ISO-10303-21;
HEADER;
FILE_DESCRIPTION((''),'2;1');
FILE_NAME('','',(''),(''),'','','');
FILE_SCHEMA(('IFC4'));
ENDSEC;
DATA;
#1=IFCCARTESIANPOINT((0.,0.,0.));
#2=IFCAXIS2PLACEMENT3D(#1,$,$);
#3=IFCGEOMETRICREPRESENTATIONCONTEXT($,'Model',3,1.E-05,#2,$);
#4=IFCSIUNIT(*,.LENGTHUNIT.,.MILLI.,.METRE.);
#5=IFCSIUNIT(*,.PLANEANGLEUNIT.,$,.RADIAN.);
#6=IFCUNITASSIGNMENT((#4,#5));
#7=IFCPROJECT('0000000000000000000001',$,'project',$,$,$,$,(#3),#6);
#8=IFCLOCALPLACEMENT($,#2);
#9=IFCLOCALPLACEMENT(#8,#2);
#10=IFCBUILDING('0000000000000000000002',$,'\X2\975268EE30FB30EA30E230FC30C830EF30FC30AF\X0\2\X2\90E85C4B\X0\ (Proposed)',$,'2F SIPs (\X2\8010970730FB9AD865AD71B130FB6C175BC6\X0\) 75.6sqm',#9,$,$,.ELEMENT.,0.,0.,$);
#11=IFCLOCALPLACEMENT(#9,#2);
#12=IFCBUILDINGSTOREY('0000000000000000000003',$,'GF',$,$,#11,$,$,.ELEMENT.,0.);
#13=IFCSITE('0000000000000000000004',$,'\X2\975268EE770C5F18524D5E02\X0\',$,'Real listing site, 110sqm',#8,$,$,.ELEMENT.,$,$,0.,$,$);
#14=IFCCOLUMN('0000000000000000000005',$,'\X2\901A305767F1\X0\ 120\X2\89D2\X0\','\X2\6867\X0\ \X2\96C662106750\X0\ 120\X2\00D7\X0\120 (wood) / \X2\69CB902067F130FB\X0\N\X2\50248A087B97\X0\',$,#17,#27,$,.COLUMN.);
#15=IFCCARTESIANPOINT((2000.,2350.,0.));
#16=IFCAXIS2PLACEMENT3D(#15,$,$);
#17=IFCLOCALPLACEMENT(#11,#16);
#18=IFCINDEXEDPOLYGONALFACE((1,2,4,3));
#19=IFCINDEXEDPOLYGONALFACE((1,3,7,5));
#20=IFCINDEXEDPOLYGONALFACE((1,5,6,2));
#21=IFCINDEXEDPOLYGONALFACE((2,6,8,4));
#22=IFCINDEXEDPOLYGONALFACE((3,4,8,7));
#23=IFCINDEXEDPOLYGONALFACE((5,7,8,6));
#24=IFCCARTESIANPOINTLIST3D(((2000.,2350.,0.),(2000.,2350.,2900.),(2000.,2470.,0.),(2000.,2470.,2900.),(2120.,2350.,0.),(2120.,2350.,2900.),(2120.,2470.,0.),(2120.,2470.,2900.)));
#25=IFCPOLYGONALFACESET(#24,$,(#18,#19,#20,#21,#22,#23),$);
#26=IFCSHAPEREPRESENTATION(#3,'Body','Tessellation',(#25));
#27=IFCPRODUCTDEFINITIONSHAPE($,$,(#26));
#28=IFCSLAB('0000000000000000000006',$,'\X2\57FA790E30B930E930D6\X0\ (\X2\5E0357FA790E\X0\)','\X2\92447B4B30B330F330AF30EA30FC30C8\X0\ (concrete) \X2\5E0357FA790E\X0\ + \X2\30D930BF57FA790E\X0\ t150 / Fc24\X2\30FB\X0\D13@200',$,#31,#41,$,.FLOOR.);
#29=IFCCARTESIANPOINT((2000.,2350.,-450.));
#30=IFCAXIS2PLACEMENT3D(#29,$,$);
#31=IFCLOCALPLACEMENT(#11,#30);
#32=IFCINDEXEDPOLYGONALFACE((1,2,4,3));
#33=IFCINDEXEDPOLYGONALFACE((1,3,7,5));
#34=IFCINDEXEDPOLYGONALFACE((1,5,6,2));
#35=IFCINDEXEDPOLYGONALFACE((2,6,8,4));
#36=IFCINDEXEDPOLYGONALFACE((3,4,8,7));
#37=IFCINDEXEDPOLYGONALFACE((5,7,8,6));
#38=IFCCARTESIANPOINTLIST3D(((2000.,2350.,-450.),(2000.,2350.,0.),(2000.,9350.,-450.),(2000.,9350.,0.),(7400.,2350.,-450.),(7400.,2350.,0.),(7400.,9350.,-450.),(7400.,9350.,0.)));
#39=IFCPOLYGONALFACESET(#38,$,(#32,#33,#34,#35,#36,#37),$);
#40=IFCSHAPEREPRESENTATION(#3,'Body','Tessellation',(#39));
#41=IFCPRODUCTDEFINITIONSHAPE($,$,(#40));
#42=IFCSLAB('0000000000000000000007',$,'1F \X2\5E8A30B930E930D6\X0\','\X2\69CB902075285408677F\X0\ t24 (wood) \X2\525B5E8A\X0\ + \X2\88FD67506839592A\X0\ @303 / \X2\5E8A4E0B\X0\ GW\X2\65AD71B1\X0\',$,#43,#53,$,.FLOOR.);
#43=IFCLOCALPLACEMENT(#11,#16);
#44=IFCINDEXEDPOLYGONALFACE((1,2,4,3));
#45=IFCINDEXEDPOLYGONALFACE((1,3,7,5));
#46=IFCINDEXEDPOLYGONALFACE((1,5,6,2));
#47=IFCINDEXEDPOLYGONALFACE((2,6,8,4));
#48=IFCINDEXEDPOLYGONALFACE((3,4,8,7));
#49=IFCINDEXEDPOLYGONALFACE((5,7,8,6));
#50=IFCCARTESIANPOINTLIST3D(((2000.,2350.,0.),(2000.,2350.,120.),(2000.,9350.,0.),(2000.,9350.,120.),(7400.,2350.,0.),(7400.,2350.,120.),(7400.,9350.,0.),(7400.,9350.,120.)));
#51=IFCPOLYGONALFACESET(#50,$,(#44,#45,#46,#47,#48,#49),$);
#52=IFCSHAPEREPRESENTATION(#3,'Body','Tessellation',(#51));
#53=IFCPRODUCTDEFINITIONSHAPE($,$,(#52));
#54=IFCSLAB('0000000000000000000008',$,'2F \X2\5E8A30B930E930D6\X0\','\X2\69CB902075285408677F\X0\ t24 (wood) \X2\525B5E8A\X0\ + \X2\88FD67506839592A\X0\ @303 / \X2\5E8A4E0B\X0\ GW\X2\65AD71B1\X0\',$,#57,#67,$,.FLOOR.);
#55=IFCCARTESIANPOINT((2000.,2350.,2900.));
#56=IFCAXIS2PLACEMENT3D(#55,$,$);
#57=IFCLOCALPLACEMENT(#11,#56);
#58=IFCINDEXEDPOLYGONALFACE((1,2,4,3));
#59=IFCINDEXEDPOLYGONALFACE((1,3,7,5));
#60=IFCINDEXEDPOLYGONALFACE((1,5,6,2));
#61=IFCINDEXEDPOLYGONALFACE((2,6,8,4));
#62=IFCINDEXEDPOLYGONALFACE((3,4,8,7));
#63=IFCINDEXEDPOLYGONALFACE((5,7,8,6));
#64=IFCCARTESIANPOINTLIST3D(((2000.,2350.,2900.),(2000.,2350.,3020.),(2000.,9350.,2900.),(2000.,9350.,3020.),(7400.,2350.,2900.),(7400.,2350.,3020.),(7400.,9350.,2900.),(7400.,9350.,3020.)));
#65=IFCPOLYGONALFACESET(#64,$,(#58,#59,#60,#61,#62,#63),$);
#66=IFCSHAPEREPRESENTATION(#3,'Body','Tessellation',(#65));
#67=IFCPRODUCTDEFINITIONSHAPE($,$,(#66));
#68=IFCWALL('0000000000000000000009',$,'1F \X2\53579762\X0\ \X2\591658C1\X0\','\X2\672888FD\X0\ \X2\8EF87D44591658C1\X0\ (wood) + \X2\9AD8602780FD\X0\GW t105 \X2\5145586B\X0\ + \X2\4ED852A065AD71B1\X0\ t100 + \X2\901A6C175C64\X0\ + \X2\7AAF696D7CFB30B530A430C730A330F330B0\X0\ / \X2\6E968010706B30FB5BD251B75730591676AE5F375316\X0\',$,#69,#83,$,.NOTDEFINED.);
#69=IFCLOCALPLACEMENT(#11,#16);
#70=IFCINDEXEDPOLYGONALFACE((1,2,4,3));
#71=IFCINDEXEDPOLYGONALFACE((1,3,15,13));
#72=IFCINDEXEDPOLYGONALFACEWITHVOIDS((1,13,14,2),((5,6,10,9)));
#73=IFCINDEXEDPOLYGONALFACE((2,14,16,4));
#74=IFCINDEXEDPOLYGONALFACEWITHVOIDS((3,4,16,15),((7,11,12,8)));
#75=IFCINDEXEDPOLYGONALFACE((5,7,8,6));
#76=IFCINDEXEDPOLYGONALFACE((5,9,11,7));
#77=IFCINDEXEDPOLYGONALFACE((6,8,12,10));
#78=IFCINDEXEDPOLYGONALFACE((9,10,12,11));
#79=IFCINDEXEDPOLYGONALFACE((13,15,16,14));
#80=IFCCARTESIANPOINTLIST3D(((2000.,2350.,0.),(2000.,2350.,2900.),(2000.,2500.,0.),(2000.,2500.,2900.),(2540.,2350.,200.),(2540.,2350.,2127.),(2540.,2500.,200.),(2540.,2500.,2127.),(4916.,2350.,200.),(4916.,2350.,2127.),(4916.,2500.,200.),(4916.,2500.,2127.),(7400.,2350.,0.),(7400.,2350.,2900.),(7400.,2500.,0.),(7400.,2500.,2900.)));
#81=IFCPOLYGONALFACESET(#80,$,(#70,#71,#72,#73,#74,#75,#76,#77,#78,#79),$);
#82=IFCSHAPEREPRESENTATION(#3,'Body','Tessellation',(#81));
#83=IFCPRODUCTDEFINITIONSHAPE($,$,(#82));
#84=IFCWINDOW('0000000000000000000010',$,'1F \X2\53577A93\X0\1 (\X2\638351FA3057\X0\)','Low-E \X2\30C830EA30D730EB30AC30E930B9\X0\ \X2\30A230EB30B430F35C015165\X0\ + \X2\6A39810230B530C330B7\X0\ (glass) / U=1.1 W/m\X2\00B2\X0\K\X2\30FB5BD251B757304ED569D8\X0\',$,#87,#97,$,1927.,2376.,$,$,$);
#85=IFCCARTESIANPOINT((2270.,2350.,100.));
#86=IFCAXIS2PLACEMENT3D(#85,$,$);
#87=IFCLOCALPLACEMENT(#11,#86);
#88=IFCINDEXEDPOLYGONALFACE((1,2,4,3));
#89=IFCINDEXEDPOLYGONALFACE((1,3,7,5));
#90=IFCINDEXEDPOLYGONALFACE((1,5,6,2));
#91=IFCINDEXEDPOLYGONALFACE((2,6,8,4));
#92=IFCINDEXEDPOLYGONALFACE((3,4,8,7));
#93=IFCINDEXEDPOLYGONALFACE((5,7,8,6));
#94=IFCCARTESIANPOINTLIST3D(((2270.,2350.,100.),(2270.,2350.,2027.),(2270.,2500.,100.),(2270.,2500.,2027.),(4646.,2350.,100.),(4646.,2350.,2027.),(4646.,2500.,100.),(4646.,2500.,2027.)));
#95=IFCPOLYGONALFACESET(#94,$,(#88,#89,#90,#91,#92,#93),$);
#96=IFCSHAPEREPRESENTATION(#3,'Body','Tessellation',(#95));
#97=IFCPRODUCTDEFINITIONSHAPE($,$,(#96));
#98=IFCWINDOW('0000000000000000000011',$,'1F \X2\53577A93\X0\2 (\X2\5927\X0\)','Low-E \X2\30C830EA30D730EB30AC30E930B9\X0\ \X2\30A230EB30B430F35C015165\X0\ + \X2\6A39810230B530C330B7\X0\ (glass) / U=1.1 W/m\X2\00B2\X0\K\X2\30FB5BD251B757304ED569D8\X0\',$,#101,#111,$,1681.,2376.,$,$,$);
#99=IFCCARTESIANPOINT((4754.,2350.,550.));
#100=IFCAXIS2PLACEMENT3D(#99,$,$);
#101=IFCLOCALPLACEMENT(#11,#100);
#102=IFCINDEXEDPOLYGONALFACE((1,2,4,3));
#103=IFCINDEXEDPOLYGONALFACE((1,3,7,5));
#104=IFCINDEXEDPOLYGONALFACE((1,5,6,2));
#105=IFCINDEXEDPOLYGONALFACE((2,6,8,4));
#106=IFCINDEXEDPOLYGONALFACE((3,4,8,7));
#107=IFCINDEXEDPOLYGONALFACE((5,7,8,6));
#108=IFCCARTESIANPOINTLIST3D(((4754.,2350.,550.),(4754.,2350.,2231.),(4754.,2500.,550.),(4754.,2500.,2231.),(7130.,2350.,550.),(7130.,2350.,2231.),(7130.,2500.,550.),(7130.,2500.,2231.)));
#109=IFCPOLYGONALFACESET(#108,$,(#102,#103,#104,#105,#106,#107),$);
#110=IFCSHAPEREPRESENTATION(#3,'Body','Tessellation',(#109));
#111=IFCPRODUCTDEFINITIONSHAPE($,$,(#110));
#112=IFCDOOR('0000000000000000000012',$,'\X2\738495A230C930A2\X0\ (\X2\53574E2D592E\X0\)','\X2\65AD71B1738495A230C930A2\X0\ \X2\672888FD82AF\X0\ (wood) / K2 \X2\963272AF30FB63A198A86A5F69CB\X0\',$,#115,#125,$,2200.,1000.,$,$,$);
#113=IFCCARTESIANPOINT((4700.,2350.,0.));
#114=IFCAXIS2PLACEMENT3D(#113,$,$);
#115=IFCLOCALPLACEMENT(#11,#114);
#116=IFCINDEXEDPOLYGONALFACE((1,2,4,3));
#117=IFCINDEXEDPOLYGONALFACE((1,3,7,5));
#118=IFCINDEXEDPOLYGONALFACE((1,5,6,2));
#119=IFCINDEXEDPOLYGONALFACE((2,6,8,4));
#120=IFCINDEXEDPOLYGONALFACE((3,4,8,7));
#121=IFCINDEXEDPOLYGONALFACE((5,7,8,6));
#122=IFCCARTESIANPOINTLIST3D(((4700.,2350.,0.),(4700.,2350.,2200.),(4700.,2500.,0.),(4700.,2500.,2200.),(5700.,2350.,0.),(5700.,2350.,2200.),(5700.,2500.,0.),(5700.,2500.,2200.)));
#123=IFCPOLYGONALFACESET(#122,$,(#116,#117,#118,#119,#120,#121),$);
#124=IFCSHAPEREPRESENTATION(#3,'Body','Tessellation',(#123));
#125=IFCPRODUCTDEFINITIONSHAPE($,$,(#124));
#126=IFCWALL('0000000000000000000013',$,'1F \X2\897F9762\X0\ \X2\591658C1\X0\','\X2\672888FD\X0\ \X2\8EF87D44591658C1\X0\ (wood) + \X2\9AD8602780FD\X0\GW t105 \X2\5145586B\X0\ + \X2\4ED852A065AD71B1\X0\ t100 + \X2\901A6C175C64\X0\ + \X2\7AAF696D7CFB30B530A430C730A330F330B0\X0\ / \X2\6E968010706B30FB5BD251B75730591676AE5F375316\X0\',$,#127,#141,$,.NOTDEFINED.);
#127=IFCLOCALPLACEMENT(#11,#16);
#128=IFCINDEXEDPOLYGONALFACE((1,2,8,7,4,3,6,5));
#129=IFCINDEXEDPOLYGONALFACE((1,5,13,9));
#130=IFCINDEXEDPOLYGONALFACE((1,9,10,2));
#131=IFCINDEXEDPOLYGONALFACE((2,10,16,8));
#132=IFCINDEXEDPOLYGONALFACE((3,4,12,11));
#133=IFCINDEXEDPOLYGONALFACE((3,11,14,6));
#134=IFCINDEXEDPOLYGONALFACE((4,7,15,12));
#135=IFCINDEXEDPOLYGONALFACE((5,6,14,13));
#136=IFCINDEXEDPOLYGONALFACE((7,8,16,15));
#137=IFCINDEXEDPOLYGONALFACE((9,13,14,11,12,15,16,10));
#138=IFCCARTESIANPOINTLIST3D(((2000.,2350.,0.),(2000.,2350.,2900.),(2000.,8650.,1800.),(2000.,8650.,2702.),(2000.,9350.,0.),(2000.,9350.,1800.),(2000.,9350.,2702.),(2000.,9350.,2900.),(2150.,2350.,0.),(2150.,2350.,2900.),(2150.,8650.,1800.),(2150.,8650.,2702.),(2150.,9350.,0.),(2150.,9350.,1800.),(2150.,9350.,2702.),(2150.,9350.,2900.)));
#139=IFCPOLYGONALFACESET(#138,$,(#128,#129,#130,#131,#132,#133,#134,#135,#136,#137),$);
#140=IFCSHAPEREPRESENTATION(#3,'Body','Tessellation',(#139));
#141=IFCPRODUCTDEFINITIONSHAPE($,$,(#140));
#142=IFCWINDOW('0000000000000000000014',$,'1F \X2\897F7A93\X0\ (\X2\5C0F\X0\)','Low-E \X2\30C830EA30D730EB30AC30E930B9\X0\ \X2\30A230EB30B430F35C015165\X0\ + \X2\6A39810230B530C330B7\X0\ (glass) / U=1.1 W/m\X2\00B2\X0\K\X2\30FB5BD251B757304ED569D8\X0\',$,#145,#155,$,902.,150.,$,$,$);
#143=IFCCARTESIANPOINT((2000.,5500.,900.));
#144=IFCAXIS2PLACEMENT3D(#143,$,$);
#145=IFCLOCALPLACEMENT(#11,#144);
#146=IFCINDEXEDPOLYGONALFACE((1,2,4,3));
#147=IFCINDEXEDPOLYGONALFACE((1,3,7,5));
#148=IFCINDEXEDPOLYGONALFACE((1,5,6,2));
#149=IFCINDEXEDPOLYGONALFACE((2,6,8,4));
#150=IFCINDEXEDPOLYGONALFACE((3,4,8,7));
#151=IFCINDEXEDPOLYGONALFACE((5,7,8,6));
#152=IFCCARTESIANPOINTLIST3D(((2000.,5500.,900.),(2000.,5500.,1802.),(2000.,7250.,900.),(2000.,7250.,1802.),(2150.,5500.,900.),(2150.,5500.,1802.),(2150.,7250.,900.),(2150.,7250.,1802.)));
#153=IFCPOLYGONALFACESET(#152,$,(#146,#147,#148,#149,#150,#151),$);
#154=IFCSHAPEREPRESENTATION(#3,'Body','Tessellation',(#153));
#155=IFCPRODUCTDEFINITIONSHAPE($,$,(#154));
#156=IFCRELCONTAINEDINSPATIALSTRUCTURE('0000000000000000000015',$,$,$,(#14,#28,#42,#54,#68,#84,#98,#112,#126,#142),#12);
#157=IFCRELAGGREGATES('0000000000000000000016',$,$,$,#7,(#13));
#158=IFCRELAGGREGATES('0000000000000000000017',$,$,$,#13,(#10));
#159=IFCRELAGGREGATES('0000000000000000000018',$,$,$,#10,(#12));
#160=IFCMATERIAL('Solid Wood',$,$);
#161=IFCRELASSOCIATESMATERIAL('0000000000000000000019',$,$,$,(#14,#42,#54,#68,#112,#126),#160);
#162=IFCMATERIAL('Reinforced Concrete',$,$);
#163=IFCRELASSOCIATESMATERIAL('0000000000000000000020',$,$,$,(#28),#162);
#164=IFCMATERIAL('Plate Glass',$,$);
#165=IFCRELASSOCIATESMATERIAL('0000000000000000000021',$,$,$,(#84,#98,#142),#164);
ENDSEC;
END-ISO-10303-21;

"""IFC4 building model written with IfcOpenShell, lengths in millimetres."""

from ifc_helpers import new_model, si_unit, frame, frame_2d, origin, place, context, project, spatial, rectangle, extrude, material, element, fill, save


model = new_model("IFC4")

# Units and contexts
model_context = context("Model", 3, precision=1e-05, world=origin())
ifc_project = project(units=[si_unit("LENGTHUNIT", "METRE", prefix="MILLI"), si_unit("PLANEANGLEUNIT", "RADIAN")], contexts=[model_context])

# Site, building, storey
site_placement = place(None, origin())
site = spatial("IfcSite", under=ifc_project, at=site_placement, Name="青森県弘前市", ObjectType="Real listing site, 110sqm", CompositionType="ELEMENT", RefElevation=0.0)
building_placement = place(site_placement, origin())
building = spatial("IfcBuilding", under=site, at=building_placement, Name="青森・リモートワーク2部屋 (Proposed)", ObjectType="2F SIPs (耐震・高断熱・気密) 75.6sqm", CompositionType="ELEMENT", ElevationOfRefHeight=0.0, ElevationOfTerrain=0.0)
storey_placement = place(building_placement, origin())
storey = spatial("IfcBuildingStorey", under=building, at=storey_placement, Name="GF", CompositionType="ELEMENT", Elevation=0.0)

# Column
ifc_material_1 = material(Name="Solid Wood")
column_placement = place(storey_placement, frame((2000.0, 2350.0, 0.0)))
element("IfcColumn", 1, at=column_placement, inside=storey, material=ifc_material_1, Name="通し柱 120角", Description="桧 集成材 120×120 (wood) / 構造柱・N値計算", PredefinedType="COLUMN", context=model_context, shape_type="SweptSolid", body=[
    extrude(rectangle(XDim=120.0, YDim=120.0, at=frame_2d((60.0, 60.0))), frame((2000.0, 2350.0, 0.0)), (0.0, 0.0, 1.0), 2900.0),
])

# Slabs
ifc_material_2 = material(Name="Reinforced Concrete")
slab_1_placement = place(storey_placement, frame((2000.0, 2350.0, -450.0)))
element("IfcSlab", 2, at=slab_1_placement, inside=storey, material=ifc_material_2, Name="基礎スラブ (布基礎)", Description="鉄筋コンクリート (concrete) 布基礎 + ベタ基礎 t150 / Fc24・D13@200", PredefinedType="FLOOR", context=model_context, shape_type="SweptSolid", body=[
    extrude(rectangle(XDim=5400.0, YDim=7000.0, at=frame_2d((2700.0, 3500.0))), frame((2000.0, 2350.0, -450.0)), (0.0, 0.0, 1.0), 450.0),
])
slab_2_placement = place(storey_placement, frame((2000.0, 2350.0, 0.0)))
element("IfcSlab", 3, at=slab_2_placement, inside=storey, material=ifc_material_1, Name="1F 床スラブ", Description="構造用合板 t24 (wood) 剛床 + 製材根太 @303 / 床下 GW断熱", PredefinedType="FLOOR", context=model_context, shape_type="SweptSolid", body=[
    extrude(rectangle(XDim=5400.0, YDim=7000.0, at=frame_2d((2700.0, 3500.0))), frame((2000.0, 2350.0, 0.0)), (0.0, 0.0, 1.0), 120.0),
])
slab_3_placement = place(storey_placement, frame((2000.0, 2350.0, 2900.0)))
element("IfcSlab", 4, at=slab_3_placement, inside=storey, material=ifc_material_1, Name="2F 床スラブ", Description="構造用合板 t24 (wood) 剛床 + 製材根太 @303 / 床下 GW断熱", PredefinedType="FLOOR", context=model_context, shape_type="SweptSolid", body=[
    extrude(rectangle(XDim=5400.0, YDim=7000.0, at=frame_2d((2700.0, 3500.0))), frame((2000.0, 2350.0, 2900.0)), (0.0, 0.0, 1.0), 120.0),
])

# Wall, openings, windows, door
wall_1_placement = place(storey_placement, frame((2000.0, 2350.0, 0.0)))
wall_1 = element("IfcWall", 5, at=wall_1_placement, inside=storey, material=ifc_material_1, Name="1F 南面 外壁", Description="木製 軸組外壁 (wood) + 高性能GW t105 充填 + 付加断熱 t100 + 通気層 + 窯業系サイディング / 準耐火・寒冷地外皮強化", PredefinedType="NOTDEFINED", context=model_context, shape_type="SweptSolid", body=[
    extrude(rectangle(XDim=5400.0, YDim=150.0, at=frame_2d((2700.0, 75.0))), frame((2000.0, 2350.0, 0.0)), (0.0, 0.0, 1.0), 2900.0),
])
opening_1_placement = place(storey_placement, frame((2270.0, 2350.0, 100.0)))
opening_1 = element("IfcOpeningElement", 6, at=opening_1_placement, cuts=wall_1, PredefinedType="NOTDEFINED", context=model_context, shape_type="SweptSolid", body=[
    extrude(rectangle(XDim=2376.0, YDim=150.0, at=frame_2d((1188.0, 75.0))), frame((2270.0, 2350.0, 100.0)), (0.0, 0.0, 1.0), 1927.0),
])
opening_2_placement = place(storey_placement, frame((4754.0, 2350.0, 550.0)))
opening_2 = element("IfcOpeningElement", 7, at=opening_2_placement, cuts=wall_1, PredefinedType="NOTDEFINED", context=model_context, shape_type="SweptSolid", body=[
    extrude(rectangle(XDim=2376.0, YDim=150.0, at=frame_2d((1188.0, 75.0))), frame((4754.0, 2350.0, 550.0)), (0.0, 0.0, 1.0), 1681.0),
])
opening_3_placement = place(storey_placement, frame((4700.0, 2350.0, 0.0)))
opening_3 = element("IfcOpeningElement", 8, at=opening_3_placement, cuts=wall_1, PredefinedType="NOTDEFINED", context=model_context, shape_type="SweptSolid", body=[
    extrude(rectangle(XDim=1000.0, YDim=150.0, at=frame_2d((500.0, 75.0))), frame((4700.0, 2350.0, 0.0)), (0.0, 0.0, 1.0), 2200.0),
])
ifc_material_3 = material(Name="Plate Glass")
window_1_placement = place(storey_placement, frame((2270.0, 2350.0, 100.0)))
window_1 = element("IfcWindow", 9, at=window_1_placement, inside=storey, material=ifc_material_3, Name="1F 南窓1 (掃出し)", Description="Low-E トリプルガラス アルゴン封入 + 樹脂サッシ (glass) / U=1.1 W/m²K・寒冷地仕様", OverallHeight=1927.0, OverallWidth=2376.0, context=model_context, shape_type="SweptSolid", body=[
    extrude(rectangle(XDim=2376.0, YDim=150.0, at=frame_2d((1188.0, 75.0))), frame((2270.0, 2350.0, 100.0)), (0.0, 0.0, 1.0), 1927.0),
])
fill(opening_1, window_1)
window_2_placement = place(storey_placement, frame((4754.0, 2350.0, 550.0)))
window_2 = element("IfcWindow", 10, at=window_2_placement, inside=storey, material=ifc_material_3, Name="1F 南窓2 (大)", Description="Low-E トリプルガラス アルゴン封入 + 樹脂サッシ (glass) / U=1.1 W/m²K・寒冷地仕様", OverallHeight=1681.0, OverallWidth=2376.0, context=model_context, shape_type="SweptSolid", body=[
    extrude(rectangle(XDim=2376.0, YDim=150.0, at=frame_2d((1188.0, 75.0))), frame((4754.0, 2350.0, 550.0)), (0.0, 0.0, 1.0), 1681.0),
])
fill(opening_2, window_2)
door_placement = place(storey_placement, frame((4700.0, 2350.0, 0.0)))
door = element("IfcDoor", 11, at=door_placement, inside=storey, material=ifc_material_1, Name="玄関ドア (南中央)", Description="断熱玄関ドア 木製芯 (wood) / K2 防犯・採風機構", OverallHeight=2200.0, OverallWidth=1000.0, context=model_context, shape_type="SweptSolid", body=[
    extrude(rectangle(XDim=1000.0, YDim=150.0, at=frame_2d((500.0, 75.0))), frame((4700.0, 2350.0, 0.0)), (0.0, 0.0, 1.0), 2200.0),
])
fill(opening_3, door)

# Wall, opening, window
wall_2_placement = place(storey_placement, frame((2000.0, 2350.0, 0.0)))
wall_2 = element("IfcWall", 12, at=wall_2_placement, inside=storey, material=ifc_material_1, Name="1F 西面 外壁", Description="木製 軸組外壁 (wood) + 高性能GW t105 充填 + 付加断熱 t100 + 通気層 + 窯業系サイディング / 準耐火・寒冷地外皮強化", PredefinedType="NOTDEFINED", context=model_context, shape_type="SweptSolid", body=[
    extrude(rectangle(XDim=150.0, YDim=7000.0, at=frame_2d((75.0, 3500.0))), frame((2000.0, 2350.0, 0.0)), (0.0, 0.0, 1.0), 2900.0),
])
opening_4_placement = place(storey_placement, frame((2000.0, 5500.0, 900.0)))
opening_4 = element("IfcOpeningElement", 13, at=opening_4_placement, cuts=wall_2, PredefinedType="NOTDEFINED", context=model_context, shape_type="SweptSolid", body=[
    extrude(rectangle(XDim=150.0, YDim=1750.0, at=frame_2d((75.0, 875.0))), frame((2000.0, 5500.0, 900.0)), (0.0, 0.0, 1.0), 902.0),
])
window_3_placement = place(storey_placement, frame((2000.0, 5500.0, 900.0)))
window_3 = element("IfcWindow", 14, at=window_3_placement, inside=storey, material=ifc_material_3, Name="1F 西窓 (小)", Description="Low-E トリプルガラス アルゴン封入 + 樹脂サッシ (glass) / U=1.1 W/m²K・寒冷地仕様", OverallHeight=902.0, OverallWidth=150.0, context=model_context, shape_type="SweptSolid", body=[
    extrude(rectangle(XDim=150.0, YDim=1750.0, at=frame_2d((75.0, 875.0))), frame((2000.0, 5500.0, 900.0)), (0.0, 0.0, 1.0), 902.0),
])
fill(opening_4, window_3)

save(model, "model.ifc")
